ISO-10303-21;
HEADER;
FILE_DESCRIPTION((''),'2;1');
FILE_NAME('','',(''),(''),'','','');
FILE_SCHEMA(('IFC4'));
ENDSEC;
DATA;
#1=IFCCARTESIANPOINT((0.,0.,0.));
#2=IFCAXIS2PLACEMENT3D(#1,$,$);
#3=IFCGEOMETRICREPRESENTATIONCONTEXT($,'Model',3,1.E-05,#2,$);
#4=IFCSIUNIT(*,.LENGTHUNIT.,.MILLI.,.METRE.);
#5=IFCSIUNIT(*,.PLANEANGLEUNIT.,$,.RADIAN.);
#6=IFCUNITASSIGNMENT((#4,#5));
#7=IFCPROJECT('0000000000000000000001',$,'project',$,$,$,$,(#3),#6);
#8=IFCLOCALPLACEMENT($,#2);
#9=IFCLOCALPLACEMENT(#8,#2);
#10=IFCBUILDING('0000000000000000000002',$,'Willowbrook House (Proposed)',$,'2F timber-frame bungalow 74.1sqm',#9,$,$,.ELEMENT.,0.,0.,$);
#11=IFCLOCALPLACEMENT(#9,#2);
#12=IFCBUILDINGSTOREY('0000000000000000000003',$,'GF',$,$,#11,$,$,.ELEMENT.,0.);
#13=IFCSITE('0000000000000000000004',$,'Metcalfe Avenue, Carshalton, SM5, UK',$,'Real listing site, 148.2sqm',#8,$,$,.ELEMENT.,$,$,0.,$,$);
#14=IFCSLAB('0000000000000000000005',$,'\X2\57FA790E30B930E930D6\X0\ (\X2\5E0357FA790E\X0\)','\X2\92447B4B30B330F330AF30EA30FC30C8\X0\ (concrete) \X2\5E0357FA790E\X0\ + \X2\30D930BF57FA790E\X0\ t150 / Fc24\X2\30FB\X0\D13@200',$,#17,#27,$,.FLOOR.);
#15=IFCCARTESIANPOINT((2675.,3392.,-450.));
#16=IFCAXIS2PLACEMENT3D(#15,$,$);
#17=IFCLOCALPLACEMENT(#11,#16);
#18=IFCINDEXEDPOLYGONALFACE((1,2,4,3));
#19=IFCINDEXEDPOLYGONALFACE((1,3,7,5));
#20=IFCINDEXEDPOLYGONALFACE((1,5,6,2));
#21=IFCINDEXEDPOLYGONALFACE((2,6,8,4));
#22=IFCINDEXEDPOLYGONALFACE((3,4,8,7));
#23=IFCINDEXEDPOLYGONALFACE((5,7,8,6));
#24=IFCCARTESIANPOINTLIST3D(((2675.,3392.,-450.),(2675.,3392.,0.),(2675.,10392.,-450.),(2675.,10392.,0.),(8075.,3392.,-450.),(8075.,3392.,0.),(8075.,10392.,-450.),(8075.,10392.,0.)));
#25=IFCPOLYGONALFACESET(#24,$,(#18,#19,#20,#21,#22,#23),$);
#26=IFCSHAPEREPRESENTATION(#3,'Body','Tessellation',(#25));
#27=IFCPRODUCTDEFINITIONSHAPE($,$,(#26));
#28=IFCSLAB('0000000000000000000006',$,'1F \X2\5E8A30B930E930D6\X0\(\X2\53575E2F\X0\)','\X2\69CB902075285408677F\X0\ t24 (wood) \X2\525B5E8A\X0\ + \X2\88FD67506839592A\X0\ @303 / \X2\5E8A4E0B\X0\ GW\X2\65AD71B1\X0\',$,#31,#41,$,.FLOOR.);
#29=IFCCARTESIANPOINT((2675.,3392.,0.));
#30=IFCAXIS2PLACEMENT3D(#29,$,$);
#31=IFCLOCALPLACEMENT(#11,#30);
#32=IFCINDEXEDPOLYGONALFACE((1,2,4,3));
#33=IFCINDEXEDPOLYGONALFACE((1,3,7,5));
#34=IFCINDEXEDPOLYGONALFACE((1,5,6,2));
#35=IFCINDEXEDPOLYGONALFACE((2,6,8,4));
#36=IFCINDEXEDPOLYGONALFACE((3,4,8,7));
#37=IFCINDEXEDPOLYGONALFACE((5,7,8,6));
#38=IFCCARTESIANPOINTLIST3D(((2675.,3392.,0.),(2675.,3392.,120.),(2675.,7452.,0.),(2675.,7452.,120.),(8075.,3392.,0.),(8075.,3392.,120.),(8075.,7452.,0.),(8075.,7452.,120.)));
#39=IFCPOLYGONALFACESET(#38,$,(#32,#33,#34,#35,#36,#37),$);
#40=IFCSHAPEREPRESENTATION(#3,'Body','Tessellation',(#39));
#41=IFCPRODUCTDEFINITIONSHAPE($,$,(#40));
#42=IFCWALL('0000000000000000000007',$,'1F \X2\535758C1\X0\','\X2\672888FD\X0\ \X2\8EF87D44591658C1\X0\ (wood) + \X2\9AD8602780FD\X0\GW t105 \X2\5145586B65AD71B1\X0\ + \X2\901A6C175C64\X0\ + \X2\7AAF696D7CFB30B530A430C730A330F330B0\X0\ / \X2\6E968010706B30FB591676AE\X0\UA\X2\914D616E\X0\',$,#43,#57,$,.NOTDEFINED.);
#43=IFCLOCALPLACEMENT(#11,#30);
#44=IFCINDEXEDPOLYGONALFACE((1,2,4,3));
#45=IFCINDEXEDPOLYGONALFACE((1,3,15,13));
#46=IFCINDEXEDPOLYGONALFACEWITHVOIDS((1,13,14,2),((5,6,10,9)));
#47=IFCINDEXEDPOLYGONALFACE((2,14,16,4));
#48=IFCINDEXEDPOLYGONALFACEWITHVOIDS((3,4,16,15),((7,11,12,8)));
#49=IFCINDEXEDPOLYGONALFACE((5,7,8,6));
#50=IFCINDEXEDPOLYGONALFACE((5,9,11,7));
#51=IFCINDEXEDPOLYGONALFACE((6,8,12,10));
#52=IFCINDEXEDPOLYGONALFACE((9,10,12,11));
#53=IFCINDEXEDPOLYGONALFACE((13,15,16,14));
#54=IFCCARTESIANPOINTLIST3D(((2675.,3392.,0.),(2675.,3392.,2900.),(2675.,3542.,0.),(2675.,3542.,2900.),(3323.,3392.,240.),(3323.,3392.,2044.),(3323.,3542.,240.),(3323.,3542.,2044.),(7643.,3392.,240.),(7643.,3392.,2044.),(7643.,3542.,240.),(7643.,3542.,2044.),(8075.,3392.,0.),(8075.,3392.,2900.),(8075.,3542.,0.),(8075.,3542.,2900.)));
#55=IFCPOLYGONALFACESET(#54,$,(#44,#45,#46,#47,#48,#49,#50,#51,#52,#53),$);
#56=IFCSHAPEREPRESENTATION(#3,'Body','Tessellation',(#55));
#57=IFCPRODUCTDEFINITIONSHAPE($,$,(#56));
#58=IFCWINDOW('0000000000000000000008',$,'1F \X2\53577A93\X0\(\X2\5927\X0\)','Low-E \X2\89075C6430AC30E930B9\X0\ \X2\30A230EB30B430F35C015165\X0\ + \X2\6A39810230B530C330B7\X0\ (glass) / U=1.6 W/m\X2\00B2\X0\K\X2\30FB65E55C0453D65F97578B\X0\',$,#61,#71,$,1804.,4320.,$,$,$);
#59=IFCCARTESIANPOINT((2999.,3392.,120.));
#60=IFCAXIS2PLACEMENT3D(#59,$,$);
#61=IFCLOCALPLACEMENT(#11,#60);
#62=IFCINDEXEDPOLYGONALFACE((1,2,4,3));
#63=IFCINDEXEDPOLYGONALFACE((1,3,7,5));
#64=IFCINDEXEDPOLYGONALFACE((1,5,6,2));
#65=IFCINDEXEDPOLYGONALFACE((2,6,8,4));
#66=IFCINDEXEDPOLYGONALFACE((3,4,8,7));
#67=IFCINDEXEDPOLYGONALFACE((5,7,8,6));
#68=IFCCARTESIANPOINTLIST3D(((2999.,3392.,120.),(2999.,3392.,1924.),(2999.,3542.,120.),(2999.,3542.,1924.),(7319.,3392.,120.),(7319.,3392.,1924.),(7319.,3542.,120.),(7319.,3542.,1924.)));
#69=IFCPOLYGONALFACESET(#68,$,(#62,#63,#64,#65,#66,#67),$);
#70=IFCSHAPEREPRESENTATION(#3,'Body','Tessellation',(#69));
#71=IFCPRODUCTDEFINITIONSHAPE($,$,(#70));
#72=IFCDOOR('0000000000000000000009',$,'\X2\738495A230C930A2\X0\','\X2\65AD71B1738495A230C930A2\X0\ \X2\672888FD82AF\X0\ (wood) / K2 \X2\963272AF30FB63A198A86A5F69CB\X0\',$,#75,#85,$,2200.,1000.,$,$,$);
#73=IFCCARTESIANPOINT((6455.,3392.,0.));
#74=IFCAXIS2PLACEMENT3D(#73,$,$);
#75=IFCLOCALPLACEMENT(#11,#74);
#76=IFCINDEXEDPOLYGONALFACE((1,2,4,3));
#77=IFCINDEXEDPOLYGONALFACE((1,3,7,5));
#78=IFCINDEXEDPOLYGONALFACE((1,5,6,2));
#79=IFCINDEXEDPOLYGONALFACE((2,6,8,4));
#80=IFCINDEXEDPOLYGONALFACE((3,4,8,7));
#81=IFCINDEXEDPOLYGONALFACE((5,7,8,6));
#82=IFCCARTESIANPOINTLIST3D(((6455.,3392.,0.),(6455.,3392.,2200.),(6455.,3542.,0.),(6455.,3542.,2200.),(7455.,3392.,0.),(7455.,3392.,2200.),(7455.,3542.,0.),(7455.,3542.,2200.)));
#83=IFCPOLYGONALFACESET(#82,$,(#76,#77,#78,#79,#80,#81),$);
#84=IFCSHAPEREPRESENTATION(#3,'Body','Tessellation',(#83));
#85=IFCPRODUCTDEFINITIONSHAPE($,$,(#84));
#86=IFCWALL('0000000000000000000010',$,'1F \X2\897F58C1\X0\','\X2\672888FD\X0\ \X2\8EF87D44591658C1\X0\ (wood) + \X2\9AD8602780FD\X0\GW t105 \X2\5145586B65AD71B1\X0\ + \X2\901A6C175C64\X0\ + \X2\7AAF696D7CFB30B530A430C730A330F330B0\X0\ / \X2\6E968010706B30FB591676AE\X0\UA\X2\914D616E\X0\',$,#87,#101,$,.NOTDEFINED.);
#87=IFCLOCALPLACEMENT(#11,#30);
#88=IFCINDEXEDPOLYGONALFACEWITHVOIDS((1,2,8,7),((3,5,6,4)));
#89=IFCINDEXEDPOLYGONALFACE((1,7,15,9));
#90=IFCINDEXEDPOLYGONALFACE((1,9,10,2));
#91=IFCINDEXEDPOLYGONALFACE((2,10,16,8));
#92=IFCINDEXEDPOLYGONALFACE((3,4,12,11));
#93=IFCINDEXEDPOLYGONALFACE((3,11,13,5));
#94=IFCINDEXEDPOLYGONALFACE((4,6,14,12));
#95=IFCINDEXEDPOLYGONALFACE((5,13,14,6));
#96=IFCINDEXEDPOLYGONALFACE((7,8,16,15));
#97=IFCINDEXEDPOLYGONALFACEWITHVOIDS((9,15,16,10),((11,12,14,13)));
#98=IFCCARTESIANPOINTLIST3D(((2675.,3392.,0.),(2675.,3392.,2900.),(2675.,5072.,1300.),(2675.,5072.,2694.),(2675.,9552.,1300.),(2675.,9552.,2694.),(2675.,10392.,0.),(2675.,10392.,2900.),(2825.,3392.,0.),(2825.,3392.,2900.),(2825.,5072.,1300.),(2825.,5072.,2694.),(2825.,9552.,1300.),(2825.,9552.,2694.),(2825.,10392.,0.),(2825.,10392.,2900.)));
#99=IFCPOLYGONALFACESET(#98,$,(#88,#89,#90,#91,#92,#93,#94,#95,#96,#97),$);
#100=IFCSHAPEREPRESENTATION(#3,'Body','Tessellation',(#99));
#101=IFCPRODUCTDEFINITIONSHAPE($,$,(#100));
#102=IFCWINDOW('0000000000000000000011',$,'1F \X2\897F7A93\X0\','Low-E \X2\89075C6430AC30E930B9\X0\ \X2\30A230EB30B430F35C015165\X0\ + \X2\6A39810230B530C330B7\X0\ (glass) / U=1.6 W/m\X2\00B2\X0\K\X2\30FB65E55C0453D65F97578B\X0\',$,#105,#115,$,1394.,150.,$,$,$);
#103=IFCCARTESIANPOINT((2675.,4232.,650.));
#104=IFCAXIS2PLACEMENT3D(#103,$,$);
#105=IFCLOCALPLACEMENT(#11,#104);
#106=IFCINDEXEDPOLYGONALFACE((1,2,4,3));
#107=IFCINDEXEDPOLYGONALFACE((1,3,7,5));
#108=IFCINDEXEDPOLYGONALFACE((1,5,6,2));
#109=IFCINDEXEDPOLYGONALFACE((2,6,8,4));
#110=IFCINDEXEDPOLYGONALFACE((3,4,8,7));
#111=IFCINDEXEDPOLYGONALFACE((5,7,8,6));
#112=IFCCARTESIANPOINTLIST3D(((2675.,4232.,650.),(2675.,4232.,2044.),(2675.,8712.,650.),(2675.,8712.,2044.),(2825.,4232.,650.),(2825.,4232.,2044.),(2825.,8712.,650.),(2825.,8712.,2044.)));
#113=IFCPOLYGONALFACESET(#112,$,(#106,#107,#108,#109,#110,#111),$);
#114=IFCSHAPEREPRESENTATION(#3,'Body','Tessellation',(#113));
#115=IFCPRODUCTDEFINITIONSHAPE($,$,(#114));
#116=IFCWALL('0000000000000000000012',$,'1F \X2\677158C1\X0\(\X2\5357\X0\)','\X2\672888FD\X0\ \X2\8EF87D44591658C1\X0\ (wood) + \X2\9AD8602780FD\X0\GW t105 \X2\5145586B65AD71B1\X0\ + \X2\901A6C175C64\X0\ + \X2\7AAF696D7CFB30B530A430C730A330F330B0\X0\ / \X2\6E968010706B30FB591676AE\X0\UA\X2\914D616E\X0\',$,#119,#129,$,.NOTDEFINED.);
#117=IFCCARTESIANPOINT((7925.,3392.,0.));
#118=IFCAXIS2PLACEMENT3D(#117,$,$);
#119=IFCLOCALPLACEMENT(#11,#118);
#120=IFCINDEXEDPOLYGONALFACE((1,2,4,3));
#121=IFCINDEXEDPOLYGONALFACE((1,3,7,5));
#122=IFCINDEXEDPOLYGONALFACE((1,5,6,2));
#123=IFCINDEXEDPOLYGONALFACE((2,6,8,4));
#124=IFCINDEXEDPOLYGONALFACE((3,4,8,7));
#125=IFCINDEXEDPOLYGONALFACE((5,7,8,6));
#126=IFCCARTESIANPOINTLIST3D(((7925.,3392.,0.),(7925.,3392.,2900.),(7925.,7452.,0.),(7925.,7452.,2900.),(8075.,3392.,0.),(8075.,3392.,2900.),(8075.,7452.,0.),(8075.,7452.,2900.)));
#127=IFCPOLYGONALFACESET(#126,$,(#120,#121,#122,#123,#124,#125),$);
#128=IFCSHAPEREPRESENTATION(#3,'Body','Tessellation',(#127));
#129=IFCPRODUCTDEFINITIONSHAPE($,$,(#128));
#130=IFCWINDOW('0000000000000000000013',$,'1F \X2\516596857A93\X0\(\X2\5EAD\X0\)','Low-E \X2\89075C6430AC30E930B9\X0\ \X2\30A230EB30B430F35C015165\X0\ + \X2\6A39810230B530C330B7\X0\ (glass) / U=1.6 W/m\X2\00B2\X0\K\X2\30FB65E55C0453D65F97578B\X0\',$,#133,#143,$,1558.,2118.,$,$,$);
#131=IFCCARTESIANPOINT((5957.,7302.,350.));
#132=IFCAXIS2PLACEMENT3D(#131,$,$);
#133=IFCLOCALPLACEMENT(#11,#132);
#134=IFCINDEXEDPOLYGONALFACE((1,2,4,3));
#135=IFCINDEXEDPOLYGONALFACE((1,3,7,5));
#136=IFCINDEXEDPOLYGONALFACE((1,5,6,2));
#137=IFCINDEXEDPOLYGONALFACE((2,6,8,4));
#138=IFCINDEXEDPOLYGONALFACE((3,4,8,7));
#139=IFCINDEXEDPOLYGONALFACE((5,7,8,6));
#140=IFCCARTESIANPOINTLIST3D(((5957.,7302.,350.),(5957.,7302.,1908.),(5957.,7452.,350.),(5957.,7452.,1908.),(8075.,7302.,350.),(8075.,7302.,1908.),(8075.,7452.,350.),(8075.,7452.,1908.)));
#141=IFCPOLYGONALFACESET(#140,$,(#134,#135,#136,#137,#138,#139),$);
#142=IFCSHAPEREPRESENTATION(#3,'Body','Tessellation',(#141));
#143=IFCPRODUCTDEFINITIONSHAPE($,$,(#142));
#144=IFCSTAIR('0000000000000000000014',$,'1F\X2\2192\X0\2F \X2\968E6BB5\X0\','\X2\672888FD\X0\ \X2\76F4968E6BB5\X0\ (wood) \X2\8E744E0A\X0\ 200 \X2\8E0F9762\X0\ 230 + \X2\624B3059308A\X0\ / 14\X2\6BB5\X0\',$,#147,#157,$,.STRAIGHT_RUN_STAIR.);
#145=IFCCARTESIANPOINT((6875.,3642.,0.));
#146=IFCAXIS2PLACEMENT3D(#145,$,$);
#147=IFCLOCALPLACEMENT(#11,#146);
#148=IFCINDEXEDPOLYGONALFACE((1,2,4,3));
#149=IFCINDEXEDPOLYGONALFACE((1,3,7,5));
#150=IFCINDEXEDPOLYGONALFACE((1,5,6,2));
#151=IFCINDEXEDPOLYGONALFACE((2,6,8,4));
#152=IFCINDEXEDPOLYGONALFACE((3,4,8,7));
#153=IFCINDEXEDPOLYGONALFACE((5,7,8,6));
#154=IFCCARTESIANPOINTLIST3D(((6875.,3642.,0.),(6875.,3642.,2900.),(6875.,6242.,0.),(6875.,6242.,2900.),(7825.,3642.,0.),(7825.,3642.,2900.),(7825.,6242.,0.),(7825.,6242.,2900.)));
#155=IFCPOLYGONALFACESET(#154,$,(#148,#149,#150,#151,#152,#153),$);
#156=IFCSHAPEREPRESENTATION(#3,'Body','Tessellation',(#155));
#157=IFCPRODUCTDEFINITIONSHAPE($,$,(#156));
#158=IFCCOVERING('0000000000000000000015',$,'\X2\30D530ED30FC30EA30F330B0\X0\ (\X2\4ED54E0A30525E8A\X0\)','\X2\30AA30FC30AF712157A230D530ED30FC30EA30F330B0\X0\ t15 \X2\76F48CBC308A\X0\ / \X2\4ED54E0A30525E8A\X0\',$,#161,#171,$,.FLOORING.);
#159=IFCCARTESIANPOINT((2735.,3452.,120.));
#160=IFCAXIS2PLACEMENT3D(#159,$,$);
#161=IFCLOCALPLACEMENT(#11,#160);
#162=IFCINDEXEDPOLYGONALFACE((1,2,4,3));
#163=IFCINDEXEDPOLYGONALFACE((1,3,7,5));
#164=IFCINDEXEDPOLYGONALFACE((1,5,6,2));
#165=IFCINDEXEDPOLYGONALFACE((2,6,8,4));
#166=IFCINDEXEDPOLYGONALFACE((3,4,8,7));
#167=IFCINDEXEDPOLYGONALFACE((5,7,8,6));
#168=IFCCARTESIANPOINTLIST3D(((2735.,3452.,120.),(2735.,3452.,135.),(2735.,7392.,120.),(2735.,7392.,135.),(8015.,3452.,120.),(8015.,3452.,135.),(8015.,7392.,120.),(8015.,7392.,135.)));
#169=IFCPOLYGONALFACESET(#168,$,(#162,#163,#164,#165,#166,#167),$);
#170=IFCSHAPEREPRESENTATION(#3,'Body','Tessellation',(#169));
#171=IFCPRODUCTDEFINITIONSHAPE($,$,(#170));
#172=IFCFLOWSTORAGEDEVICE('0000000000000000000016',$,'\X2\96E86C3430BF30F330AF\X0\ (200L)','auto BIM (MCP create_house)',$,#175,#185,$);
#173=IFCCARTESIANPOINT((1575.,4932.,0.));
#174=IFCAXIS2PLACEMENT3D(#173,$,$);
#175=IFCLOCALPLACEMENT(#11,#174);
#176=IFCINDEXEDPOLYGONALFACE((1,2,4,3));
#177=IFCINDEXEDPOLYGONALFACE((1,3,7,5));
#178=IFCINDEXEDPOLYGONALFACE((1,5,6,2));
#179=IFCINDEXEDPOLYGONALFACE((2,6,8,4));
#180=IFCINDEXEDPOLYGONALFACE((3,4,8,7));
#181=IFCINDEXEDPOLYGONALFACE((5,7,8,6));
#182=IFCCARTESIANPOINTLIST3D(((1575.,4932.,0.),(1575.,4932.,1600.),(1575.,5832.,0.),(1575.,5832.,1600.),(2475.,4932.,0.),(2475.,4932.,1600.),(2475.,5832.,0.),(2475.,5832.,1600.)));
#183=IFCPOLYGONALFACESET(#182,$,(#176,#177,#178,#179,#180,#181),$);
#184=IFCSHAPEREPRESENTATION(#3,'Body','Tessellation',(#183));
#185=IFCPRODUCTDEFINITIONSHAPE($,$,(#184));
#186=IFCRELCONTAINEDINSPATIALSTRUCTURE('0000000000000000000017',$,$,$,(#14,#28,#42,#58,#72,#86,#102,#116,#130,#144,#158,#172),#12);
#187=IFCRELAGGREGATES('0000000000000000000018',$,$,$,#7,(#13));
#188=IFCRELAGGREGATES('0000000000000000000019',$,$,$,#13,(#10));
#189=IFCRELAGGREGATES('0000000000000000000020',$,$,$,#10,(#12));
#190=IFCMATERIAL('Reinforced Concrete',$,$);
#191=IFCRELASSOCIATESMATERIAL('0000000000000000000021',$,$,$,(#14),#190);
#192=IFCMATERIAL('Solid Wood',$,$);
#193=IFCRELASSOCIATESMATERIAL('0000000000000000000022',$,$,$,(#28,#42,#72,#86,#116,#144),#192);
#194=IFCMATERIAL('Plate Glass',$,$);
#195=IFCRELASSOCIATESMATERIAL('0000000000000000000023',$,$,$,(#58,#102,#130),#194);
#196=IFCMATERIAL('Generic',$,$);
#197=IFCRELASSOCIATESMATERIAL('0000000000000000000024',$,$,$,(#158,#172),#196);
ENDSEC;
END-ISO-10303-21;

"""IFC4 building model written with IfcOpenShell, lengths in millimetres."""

from ifc_helpers import new_model, si_unit, frame, frame_2d, origin, place, context, project, spatial, rectangle, extrude, material, element, fill, save


model = new_model("IFC4")

# Units and contexts
model_context = context("Model", 3, precision=1e-05, world=origin())
ifc_project = project(units=[si_unit("LENGTHUNIT", "METRE", prefix="MILLI"), si_unit("PLANEANGLEUNIT", "RADIAN")], contexts=[model_context])

# Site, building, storey
site_placement = place(None, origin())
site = spatial("IfcSite", under=ifc_project, at=site_placement, Name="Metcalfe Avenue, Carshalton, SM5, UK", ObjectType="Real listing site, 148.2sqm", CompositionType="ELEMENT", RefElevation=0.0)
building_placement = place(site_placement, origin())
building = spatial("IfcBuilding", under=site, at=building_placement, Name="Willowbrook House (Proposed)", ObjectType="2F timber-frame bungalow 74.1sqm", CompositionType="ELEMENT", ElevationOfRefHeight=0.0, ElevationOfTerrain=0.0)
storey_placement = place(building_placement, origin())
storey = spatial("IfcBuildingStorey", under=building, at=storey_placement, Name="GF", CompositionType="ELEMENT", Elevation=0.0)

# Slabs
ifc_material_1 = material(Name="Reinforced Concrete")
slab_1_placement = place(storey_placement, frame((2675.0, 3392.0, -450.0)))
element("IfcSlab", 1, at=slab_1_placement, inside=storey, material=ifc_material_1, Name="基礎スラブ (布基礎)", Description="鉄筋コンクリート (concrete) 布基礎 + ベタ基礎 t150 / Fc24・D13@200", PredefinedType="FLOOR", context=model_context, shape_type="SweptSolid", body=[
    extrude(rectangle(XDim=5400.0, YDim=7000.0, at=frame_2d((2700.0, 3500.0))), frame((2675.0, 3392.0, -450.0)), (0.0, 0.0, 1.0), 450.0),
])
ifc_material_2 = material(Name="Solid Wood")
slab_2_placement = place(storey_placement, frame((2675.0, 3392.0, 0.0)))
element("IfcSlab", 2, at=slab_2_placement, inside=storey, material=ifc_material_2, Name="1F 床スラブ(南帯)", Description="構造用合板 t24 (wood) 剛床 + 製材根太 @303 / 床下 GW断熱", PredefinedType="FLOOR", context=model_context, shape_type="SweptSolid", body=[
    extrude(rectangle(XDim=5400.0, YDim=4060.0, at=frame_2d((2700.0, 2030.0))), frame((2675.0, 3392.0, 0.0)), (0.0, 0.0, 1.0), 120.0),
])

# Wall, openings, window, door
wall_1_placement = place(storey_placement, frame((2675.0, 3392.0, 0.0)))
wall_1 = element("IfcWall", 3, at=wall_1_placement, inside=storey, material=ifc_material_2, Name="1F 南壁", Description="木製 軸組外壁 (wood) + 高性能GW t105 充填断熱 + 通気層 + 窯業系サイディング / 準耐火・外皮UA配慮", PredefinedType="NOTDEFINED", context=model_context, shape_type="SweptSolid", body=[
    extrude(rectangle(XDim=5400.0, YDim=150.0, at=frame_2d((2700.0, 75.0))), frame((2675.0, 3392.0, 0.0)), (0.0, 0.0, 1.0), 2900.0),
])
opening_1_placement = place(storey_placement, frame((2999.0, 3392.0, 120.0)))
opening_1 = element("IfcOpeningElement", 4, at=opening_1_placement, cuts=wall_1, PredefinedType="NOTDEFINED", context=model_context, shape_type="SweptSolid", body=[
    extrude(rectangle(XDim=4320.0, YDim=150.0, at=frame_2d((2160.0, 75.0))), frame((2999.0, 3392.0, 120.0)), (0.0, 0.0, 1.0), 1804.0),
])
opening_2_placement = place(storey_placement, frame((6455.0, 3392.0, 0.0)))
opening_2 = element("IfcOpeningElement", 5, at=opening_2_placement, cuts=wall_1, PredefinedType="NOTDEFINED", context=model_context, shape_type="SweptSolid", body=[
    extrude(rectangle(XDim=1000.0, YDim=150.0, at=frame_2d((500.0, 75.0))), frame((6455.0, 3392.0, 0.0)), (0.0, 0.0, 1.0), 2200.0),
])
ifc_material_3 = material(Name="Plate Glass")
window_1_placement = place(storey_placement, frame((2999.0, 3392.0, 120.0)))
window_1 = element("IfcWindow", 6, at=window_1_placement, inside=storey, material=ifc_material_3, Name="1F 南窓(大)", Description="Low-E 複層ガラス アルゴン封入 + 樹脂サッシ (glass) / U=1.6 W/m²K・日射取得型", OverallHeight=1804.0, OverallWidth=4320.0, context=model_context, shape_type="SweptSolid", body=[
    extrude(rectangle(XDim=4320.0, YDim=150.0, at=frame_2d((2160.0, 75.0))), frame((2999.0, 3392.0, 120.0)), (0.0, 0.0, 1.0), 1804.0),
])
fill(opening_1, window_1)
door_1_placement = place(storey_placement, frame((6455.0, 3392.0, 0.0)))
door_1 = element("IfcDoor", 7, at=door_1_placement, inside=storey, material=ifc_material_2, Name="玄関ドア", Description="断熱玄関ドア 木製芯 (wood) / K2 防犯・採風機構", OverallHeight=2200.0, OverallWidth=1000.0, context=model_context, shape_type="SweptSolid", body=[
    extrude(rectangle(XDim=1000.0, YDim=150.0, at=frame_2d((500.0, 75.0))), frame((6455.0, 3392.0, 0.0)), (0.0, 0.0, 1.0), 2200.0),
])
fill(opening_2, door_1)

# Walls, openings, windows
wall_2_placement = place(storey_placement, frame((2675.0, 3392.0, 0.0)))
wall_2 = element("IfcWall", 8, at=wall_2_placement, inside=storey, material=ifc_material_2, Name="1F 西壁", Description="木製 軸組外壁 (wood) + 高性能GW t105 充填断熱 + 通気層 + 窯業系サイディング / 準耐火・外皮UA配慮", PredefinedType="NOTDEFINED", context=model_context, shape_type="SweptSolid", body=[
    extrude(rectangle(XDim=150.0, YDim=7000.0, at=frame_2d((75.0, 3500.0))), frame((2675.0, 3392.0, 0.0)), (0.0, 0.0, 1.0), 2900.0),
])
opening_3_placement = place(storey_placement, frame((2675.0, 4232.0, 650.0)))
opening_3 = element("IfcOpeningElement", 9, at=opening_3_placement, cuts=wall_2, PredefinedType="NOTDEFINED", context=model_context, shape_type="SweptSolid", body=[
    extrude(rectangle(XDim=150.0, YDim=4480.0, at=frame_2d((75.0, 2240.0))), frame((2675.0, 4232.0, 650.0)), (0.0, 0.0, 1.0), 1394.0),
])
window_2_placement = place(storey_placement, frame((2675.0, 4232.0, 650.0)))
window_2 = element("IfcWindow", 10, at=window_2_placement, inside=storey, material=ifc_material_3, Name="1F 西窓", Description="Low-E 複層ガラス アルゴン封入 + 樹脂サッシ (glass) / U=1.6 W/m²K・日射取得型", OverallHeight=1394.0, OverallWidth=150.0, context=model_context, shape_type="SweptSolid", body=[
    extrude(rectangle(XDim=150.0, YDim=4480.0, at=frame_2d((75.0, 2240.0))), frame((2675.0, 4232.0, 650.0)), (0.0, 0.0, 1.0), 1394.0),
])
fill(opening_3, window_2)
wall_3_placement = place(storey_placement, frame((7925.0, 3392.0, 0.0)))
wall_3 = element("IfcWall", 11, at=wall_3_placement, inside=storey, material=ifc_material_2, Name="1F 東壁(南)", Description="木製 軸組外壁 (wood) + 高性能GW t105 充填断熱 + 通気層 + 窯業系サイディング / 準耐火・外皮UA配慮", PredefinedType="NOTDEFINED", context=model_context, shape_type="SweptSolid", body=[
    extrude(rectangle(XDim=150.0, YDim=4060.0, at=frame_2d((75.0, 2030.0))), frame((7925.0, 3392.0, 0.0)), (0.0, 0.0, 1.0), 2900.0),
])
opening_4_placement = place(storey_placement, frame((5957.0, 7302.0, 350.0)))
opening_4 = element("IfcOpeningElement", 12, at=opening_4_placement, cuts=wall_3, PredefinedType="NOTDEFINED", context=model_context, shape_type="SweptSolid", body=[
    extrude(rectangle(XDim=2118.0, YDim=150.0, at=frame_2d((1059.0, 75.0))), frame((5957.0, 7302.0, 350.0)), (0.0, 0.0, 1.0), 1558.0),
])
window_3_placement = place(storey_placement, frame((5957.0, 7302.0, 350.0)))
window_3 = element("IfcWindow", 13, at=window_3_placement, inside=storey, material=ifc_material_3, Name="1F 入隅窓(庭)", Description="Low-E 複層ガラス アルゴン封入 + 樹脂サッシ (glass) / U=1.6 W/m²K・日射取得型", OverallHeight=1558.0, OverallWidth=2118.0, context=model_context, shape_type="SweptSolid", body=[
    extrude(rectangle(XDim=2118.0, YDim=150.0, at=frame_2d((1059.0, 75.0))), frame((5957.0, 7302.0, 350.0)), (0.0, 0.0, 1.0), 1558.0),
])
fill(opening_4, window_3)

# Stair
stair_placement = place(storey_placement, frame((6875.0, 3642.0, 0.0)))
element("IfcStair", 14, at=stair_placement, inside=storey, material=ifc_material_2, Name="1F→2F 階段", Description="木製 直階段 (wood) 蹴上 200 踏面 230 + 手すり / 14段", PredefinedType="STRAIGHT_RUN_STAIR", context=model_context, shape_type="SweptSolid", body=[
    extrude(rectangle(XDim=950.0, YDim=2600.0, at=frame_2d((475.0, 1300.0))), frame((6875.0, 3642.0, 0.0)), (0.0, 0.0, 1.0), 2900.0),
])

# Covering
ifc_material_4 = material(Name="Generic")
covering_placement = place(storey_placement, frame((2735.0, 3452.0, 120.0)))
element("IfcCovering", 15, at=covering_placement, inside=storey, material=ifc_material_4, Name="フローリング (仕上げ床)", Description="オーク無垢フローリング t15 直貼り / 仕上げ床", PredefinedType="FLOORING", context=model_context, shape_type="SweptSolid", body=[
    extrude(rectangle(XDim=5280.0, YDim=3940.0, at=frame_2d((2640.0, 1970.0))), frame((2735.0, 3452.0, 120.0)), (0.0, 0.0, 1.0), 15.0),
])

# Flow storage device
flow_storage_device_placement = place(storey_placement, frame((1575.0, 4932.0, 0.0)))
element("IfcFlowStorageDevice", 16, at=flow_storage_device_placement, inside=storey, material=ifc_material_4, Name="雨水タンク (200L)", Description="auto BIM (MCP create_house)", context=model_context, shape_type="SweptSolid", body=[
    extrude(rectangle(XDim=900.0, YDim=900.0, at=frame_2d((450.0, 450.0))), frame((1575.0, 4932.0, 0.0)), (0.0, 0.0, 1.0), 1600.0),
])

save(model, "model.ifc")
